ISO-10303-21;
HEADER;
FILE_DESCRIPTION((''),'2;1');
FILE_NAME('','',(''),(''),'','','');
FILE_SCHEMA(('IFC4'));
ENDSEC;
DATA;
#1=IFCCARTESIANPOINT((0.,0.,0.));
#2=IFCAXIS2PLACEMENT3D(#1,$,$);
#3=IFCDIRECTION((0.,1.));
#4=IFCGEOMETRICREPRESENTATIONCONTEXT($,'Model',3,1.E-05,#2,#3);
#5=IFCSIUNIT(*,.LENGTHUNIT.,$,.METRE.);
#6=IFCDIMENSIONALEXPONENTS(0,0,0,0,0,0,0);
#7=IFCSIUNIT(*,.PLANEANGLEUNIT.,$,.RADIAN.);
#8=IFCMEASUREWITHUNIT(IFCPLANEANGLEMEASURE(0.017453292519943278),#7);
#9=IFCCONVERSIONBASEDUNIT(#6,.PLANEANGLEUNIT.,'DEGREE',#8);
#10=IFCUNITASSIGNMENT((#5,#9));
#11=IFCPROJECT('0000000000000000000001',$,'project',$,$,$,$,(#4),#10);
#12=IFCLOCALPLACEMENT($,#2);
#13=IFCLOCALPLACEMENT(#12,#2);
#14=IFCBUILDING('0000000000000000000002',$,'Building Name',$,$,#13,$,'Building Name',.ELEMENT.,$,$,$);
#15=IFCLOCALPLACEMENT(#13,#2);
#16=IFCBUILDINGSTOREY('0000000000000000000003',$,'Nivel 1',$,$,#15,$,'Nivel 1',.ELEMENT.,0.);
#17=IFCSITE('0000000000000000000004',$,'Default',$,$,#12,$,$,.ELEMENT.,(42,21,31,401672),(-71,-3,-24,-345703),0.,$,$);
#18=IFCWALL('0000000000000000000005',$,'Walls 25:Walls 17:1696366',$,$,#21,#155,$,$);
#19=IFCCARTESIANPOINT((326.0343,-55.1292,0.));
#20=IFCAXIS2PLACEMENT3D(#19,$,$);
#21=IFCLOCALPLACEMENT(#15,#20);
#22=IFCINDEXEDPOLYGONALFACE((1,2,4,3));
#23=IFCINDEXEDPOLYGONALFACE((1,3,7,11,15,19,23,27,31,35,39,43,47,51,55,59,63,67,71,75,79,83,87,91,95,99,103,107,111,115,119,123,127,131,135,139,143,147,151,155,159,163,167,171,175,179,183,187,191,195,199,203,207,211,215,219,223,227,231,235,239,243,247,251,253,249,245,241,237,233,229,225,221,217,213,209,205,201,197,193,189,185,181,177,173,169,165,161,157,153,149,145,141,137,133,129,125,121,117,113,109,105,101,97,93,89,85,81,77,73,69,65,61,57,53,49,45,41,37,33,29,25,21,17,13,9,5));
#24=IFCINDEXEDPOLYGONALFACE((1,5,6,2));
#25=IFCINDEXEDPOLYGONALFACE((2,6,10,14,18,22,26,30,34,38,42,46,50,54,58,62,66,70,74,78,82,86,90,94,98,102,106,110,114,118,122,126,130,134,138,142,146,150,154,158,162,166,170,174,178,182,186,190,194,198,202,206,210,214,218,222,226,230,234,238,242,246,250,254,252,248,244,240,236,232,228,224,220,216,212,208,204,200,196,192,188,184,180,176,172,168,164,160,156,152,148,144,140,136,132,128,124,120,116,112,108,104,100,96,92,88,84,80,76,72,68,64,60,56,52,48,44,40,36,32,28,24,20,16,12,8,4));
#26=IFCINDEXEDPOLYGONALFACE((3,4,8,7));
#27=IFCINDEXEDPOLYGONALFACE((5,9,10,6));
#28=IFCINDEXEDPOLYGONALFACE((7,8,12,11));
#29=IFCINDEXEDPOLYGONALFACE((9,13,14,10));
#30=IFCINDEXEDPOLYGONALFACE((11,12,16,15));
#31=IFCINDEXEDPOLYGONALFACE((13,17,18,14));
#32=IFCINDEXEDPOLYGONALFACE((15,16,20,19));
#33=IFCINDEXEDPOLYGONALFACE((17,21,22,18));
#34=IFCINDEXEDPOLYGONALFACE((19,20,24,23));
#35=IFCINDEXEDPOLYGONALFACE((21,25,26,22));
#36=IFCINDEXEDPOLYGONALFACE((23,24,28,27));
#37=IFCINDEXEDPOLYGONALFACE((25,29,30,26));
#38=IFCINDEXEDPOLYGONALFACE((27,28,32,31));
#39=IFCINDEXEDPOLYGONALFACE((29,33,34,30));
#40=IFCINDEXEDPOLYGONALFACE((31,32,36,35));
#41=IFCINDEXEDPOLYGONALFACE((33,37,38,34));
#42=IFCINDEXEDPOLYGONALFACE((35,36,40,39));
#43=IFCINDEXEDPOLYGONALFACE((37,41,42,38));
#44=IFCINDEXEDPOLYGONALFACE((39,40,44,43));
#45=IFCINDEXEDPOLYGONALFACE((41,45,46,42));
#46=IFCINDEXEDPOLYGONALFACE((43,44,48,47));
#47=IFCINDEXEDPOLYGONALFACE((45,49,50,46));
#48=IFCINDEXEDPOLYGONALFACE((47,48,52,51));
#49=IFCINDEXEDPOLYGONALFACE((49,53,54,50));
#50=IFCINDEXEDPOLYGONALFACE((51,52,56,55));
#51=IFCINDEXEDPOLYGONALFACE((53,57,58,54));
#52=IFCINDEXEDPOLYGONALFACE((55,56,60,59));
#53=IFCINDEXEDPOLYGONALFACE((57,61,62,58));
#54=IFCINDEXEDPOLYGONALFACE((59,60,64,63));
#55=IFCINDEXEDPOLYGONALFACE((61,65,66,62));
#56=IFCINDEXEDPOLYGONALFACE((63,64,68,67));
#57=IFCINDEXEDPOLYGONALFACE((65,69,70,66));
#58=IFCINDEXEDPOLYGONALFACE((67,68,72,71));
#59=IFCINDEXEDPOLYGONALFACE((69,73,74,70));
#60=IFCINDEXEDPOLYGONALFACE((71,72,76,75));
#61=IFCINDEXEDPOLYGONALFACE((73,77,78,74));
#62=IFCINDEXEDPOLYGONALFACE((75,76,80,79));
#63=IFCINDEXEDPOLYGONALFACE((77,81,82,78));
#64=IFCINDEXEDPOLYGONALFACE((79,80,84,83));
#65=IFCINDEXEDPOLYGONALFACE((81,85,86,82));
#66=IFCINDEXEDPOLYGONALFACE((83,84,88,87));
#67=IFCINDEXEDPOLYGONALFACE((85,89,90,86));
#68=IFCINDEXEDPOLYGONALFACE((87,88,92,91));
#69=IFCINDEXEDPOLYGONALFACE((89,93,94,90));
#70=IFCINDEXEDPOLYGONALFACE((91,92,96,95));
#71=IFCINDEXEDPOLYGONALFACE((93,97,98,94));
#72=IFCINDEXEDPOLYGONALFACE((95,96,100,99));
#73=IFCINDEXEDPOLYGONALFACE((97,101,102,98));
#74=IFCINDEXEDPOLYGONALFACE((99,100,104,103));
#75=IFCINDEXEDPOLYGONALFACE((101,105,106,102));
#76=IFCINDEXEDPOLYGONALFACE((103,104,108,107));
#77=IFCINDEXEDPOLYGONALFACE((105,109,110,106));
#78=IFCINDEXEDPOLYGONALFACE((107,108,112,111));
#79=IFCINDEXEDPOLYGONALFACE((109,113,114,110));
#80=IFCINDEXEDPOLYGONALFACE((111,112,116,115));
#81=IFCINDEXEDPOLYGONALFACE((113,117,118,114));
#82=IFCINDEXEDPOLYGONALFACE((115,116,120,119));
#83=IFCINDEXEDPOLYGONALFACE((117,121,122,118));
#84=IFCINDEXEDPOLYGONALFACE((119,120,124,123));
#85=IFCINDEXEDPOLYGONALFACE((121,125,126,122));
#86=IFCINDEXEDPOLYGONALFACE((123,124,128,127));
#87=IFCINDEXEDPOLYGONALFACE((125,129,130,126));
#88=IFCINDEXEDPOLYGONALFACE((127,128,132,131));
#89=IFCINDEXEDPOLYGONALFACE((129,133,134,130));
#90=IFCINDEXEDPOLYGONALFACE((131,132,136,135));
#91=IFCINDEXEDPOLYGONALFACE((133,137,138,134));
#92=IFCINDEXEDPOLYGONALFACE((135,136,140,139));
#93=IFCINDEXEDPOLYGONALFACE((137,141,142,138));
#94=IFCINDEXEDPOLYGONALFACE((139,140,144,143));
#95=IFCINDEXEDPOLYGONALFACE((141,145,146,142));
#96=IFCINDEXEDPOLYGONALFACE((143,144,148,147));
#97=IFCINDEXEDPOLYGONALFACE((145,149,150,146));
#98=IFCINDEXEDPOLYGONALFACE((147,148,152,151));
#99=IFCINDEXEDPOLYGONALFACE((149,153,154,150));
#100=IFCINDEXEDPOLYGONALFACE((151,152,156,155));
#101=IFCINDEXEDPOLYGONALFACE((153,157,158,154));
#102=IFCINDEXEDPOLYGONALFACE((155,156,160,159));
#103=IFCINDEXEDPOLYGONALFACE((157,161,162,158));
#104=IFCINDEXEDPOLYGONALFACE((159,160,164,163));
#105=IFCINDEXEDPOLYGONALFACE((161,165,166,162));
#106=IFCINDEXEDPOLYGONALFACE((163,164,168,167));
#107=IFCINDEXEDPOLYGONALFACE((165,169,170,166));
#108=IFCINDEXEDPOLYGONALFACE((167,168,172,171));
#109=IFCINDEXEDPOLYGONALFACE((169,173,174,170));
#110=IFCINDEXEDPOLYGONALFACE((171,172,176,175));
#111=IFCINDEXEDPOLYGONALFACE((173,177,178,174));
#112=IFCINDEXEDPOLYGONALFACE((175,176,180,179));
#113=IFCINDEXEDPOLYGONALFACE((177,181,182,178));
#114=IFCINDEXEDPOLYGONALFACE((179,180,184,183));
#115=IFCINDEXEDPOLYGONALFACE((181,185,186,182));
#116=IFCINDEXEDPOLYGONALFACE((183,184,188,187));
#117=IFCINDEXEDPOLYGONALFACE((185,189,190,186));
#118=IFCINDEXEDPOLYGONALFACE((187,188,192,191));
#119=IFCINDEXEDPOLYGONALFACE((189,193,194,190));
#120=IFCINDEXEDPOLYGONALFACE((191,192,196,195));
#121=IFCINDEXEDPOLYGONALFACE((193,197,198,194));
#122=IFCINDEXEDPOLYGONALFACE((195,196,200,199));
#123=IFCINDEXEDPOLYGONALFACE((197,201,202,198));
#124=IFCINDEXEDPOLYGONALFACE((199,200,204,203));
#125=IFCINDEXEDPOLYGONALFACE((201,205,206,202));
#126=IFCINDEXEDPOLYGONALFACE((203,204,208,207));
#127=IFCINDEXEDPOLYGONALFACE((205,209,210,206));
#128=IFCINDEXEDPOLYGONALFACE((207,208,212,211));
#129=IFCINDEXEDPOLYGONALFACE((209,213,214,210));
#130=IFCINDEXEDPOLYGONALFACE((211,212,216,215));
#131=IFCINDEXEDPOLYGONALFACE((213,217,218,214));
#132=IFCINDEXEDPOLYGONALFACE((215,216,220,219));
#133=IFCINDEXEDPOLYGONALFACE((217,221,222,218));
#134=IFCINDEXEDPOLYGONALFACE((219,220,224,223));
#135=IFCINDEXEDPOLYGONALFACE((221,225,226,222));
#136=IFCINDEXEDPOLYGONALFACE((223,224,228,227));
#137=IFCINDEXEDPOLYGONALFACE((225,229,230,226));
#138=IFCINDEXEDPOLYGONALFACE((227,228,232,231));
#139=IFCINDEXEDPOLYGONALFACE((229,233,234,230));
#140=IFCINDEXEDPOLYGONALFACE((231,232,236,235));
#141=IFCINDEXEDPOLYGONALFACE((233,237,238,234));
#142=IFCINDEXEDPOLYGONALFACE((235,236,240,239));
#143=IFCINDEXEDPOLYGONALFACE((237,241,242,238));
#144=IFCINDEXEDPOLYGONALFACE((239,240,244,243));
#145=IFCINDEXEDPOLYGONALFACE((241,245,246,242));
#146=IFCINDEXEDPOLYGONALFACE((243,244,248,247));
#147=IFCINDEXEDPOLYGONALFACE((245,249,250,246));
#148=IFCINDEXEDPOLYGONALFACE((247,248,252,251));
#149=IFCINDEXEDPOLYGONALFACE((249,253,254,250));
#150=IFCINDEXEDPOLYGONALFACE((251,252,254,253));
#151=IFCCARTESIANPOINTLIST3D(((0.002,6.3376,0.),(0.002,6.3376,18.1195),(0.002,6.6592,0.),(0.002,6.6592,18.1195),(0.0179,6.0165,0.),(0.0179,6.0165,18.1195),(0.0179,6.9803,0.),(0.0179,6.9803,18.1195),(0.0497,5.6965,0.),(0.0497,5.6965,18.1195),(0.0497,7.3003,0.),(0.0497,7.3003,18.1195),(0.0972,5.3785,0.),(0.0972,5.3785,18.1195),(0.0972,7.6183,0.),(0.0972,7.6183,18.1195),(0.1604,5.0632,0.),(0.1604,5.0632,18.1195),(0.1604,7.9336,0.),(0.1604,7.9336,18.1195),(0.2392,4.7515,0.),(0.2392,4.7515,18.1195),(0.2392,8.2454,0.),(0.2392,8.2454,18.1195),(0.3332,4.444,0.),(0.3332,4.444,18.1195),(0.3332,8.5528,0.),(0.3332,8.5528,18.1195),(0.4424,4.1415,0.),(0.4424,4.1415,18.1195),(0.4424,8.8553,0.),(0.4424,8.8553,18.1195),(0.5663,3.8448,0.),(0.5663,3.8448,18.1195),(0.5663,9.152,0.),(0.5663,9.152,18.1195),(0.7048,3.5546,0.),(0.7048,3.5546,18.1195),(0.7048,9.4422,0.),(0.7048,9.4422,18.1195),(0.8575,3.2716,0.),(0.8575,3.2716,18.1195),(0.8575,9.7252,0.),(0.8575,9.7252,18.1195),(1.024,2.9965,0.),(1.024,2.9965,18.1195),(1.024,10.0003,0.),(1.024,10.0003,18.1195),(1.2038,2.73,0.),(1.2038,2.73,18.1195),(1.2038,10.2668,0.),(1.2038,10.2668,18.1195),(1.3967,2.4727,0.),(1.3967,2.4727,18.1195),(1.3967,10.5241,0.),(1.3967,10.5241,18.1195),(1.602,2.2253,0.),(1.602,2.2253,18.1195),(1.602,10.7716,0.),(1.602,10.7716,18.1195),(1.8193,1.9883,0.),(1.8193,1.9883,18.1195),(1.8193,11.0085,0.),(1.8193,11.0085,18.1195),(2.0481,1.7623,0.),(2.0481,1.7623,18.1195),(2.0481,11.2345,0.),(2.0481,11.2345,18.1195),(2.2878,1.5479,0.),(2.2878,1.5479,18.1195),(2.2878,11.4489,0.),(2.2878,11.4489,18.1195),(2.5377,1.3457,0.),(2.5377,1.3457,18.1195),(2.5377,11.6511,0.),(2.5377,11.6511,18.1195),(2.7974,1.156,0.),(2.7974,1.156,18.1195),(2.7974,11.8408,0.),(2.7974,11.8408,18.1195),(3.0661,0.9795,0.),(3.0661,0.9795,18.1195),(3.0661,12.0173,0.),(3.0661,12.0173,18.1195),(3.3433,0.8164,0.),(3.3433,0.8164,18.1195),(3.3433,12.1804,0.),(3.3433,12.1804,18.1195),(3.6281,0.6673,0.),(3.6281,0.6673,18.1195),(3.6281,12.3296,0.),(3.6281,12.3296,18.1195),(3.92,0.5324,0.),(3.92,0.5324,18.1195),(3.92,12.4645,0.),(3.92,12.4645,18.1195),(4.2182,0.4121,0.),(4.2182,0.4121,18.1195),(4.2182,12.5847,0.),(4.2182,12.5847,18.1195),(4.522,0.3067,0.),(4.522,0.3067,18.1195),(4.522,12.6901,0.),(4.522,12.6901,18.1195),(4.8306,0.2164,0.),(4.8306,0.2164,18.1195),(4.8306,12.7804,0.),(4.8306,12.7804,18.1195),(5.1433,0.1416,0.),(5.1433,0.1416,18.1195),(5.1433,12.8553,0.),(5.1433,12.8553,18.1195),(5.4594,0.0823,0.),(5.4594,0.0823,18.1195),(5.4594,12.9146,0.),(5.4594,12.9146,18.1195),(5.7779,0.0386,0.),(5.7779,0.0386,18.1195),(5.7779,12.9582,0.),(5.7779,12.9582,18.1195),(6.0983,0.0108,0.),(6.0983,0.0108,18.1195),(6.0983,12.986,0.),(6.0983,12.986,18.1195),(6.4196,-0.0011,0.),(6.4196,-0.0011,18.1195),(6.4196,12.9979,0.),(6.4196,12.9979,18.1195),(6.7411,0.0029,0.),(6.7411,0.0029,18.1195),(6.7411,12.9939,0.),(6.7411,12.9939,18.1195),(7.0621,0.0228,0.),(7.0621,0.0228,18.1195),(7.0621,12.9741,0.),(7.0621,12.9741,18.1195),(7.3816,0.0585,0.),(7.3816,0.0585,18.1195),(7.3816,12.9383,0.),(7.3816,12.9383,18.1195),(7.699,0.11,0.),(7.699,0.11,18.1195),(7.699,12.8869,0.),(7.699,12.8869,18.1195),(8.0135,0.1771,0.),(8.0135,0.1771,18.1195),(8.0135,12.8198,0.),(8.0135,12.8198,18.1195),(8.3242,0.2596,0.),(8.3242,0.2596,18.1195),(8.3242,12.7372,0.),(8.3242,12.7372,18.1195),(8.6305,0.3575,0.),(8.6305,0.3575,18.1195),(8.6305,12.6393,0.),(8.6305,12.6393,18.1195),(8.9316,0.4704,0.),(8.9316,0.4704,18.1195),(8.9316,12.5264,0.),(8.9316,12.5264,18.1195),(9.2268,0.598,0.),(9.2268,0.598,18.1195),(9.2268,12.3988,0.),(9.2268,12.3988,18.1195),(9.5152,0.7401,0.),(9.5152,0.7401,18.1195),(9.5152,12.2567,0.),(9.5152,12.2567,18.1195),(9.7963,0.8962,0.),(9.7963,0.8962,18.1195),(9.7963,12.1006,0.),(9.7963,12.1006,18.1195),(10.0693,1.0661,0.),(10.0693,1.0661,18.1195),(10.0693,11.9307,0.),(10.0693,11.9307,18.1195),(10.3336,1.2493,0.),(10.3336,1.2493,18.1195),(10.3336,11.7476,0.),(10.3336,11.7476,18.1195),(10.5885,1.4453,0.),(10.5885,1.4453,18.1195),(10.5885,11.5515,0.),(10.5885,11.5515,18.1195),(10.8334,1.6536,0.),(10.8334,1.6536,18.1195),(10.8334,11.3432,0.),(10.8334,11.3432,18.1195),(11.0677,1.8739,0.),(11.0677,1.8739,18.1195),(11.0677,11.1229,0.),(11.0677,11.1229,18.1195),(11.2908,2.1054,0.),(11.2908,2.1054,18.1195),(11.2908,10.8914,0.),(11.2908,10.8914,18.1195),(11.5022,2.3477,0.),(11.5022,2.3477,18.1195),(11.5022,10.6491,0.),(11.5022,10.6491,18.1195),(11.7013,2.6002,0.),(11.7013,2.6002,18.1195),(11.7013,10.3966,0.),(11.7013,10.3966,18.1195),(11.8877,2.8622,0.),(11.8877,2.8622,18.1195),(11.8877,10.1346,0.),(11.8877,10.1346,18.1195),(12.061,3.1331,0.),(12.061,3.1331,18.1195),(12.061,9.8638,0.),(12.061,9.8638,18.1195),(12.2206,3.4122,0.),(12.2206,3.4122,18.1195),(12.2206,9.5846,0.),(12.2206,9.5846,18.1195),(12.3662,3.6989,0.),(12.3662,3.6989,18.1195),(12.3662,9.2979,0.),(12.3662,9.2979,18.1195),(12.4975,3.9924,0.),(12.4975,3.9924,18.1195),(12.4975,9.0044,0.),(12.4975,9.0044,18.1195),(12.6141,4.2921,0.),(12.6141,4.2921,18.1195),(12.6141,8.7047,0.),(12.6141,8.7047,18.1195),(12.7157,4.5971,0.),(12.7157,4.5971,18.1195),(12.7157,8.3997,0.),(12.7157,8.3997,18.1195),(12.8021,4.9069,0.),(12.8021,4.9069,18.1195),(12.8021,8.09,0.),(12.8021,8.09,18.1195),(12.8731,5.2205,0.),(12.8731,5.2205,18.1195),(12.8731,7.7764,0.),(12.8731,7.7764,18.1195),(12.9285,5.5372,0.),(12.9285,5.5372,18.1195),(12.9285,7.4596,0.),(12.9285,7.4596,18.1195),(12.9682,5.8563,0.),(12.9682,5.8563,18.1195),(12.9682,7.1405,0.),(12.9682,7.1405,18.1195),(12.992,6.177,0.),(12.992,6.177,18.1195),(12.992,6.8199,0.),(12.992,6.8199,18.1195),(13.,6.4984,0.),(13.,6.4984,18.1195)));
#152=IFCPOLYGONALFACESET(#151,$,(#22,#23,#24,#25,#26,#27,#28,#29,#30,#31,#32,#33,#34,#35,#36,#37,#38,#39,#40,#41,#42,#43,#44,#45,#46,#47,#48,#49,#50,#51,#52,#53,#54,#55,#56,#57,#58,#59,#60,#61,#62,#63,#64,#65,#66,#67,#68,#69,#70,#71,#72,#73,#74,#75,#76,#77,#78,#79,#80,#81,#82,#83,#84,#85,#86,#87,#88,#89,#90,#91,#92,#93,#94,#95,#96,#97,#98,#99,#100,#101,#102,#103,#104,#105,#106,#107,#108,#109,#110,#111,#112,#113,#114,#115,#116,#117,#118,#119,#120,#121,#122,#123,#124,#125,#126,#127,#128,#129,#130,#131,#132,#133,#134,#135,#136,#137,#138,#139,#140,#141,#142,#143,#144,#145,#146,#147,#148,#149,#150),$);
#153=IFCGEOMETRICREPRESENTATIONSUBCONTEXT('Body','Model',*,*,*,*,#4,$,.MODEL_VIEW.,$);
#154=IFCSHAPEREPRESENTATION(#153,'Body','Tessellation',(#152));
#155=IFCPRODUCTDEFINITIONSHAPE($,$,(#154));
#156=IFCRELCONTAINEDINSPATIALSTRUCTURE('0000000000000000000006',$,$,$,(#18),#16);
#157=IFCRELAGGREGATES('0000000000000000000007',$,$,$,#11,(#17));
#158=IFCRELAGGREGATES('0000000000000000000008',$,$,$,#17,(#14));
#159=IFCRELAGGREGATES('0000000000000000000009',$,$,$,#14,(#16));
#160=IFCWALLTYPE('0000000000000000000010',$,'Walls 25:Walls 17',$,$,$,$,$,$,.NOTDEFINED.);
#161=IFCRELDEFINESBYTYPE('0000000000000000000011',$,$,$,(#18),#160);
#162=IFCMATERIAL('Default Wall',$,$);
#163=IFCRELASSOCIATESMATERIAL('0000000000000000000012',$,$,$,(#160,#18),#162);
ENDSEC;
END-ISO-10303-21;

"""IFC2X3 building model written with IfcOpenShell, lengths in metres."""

from ifc_helpers import new_model, entity, si_unit, converted_unit, direction, frame, frame_2d, origin, place, context, subcontext, project, spatial, circle, extrude, material, type_object, element, save


model = new_model("IFC2X3")

# Units and contexts
model_context = context("Model", 3, precision=1e-05, world=origin(), true_north=direction((0.0, 1.0)))
body_context = subcontext(model_context, "Body", "Model", "MODEL_VIEW")
ifc_project = project(units=[si_unit("LENGTHUNIT", "METRE"), converted_unit("PLANEANGLEUNIT", "DEGREE", entity("IfcPlaneAngleMeasure", 0.017453292519943278), si_unit("PLANEANGLEUNIT", "RADIAN"), dimensions=[0, 0, 0, 0, 0, 0, 0])], contexts=[model_context])

# Site, building, storey
site_placement = place(None, origin())
site = spatial("IfcSite", under=ifc_project, at=site_placement, Name="Default", CompositionType="ELEMENT", RefLatitude=(42, 21, 31, 401672), RefLongitude=(-71, -3, -24, -345703), RefElevation=0.0)
building_placement = place(site_placement, origin())
building = spatial("IfcBuilding", under=site, at=building_placement, Name="Building Name", LongName="Building Name", CompositionType="ELEMENT")
storey_placement = place(building_placement, origin())
storey = spatial("IfcBuildingStorey", under=building, at=storey_placement, Name="Nivel 1", LongName="Nivel 1", CompositionType="ELEMENT", Elevation=0.0)

# Wall
ifc_material_1 = material(Name="Default Wall")
wall_type_1 = type_object("IfcWallType", Name="Walls 25:Walls 17", PredefinedType="NOTDEFINED", material=ifc_material_1)
wall_1_placement = place(storey_placement, frame((326.0343, -55.1292, 0.0)))
element("IfcWall", 1, at=wall_1_placement, inside=storey, type_object=wall_type_1, material=ifc_material_1, Name="Walls 25:Walls 17:1696366", context=body_context, shape_type="SweptSolid", body=[
    extrude(circle(Radius=6.5, at=frame_2d((0.0, 0.0), x_axis=(1.0, 0.0))), frame((6.5, 6.4984, 0.0)), (0.0, 0.0, 1.0), 18.1195),
])

save(model, "model.ifc")
